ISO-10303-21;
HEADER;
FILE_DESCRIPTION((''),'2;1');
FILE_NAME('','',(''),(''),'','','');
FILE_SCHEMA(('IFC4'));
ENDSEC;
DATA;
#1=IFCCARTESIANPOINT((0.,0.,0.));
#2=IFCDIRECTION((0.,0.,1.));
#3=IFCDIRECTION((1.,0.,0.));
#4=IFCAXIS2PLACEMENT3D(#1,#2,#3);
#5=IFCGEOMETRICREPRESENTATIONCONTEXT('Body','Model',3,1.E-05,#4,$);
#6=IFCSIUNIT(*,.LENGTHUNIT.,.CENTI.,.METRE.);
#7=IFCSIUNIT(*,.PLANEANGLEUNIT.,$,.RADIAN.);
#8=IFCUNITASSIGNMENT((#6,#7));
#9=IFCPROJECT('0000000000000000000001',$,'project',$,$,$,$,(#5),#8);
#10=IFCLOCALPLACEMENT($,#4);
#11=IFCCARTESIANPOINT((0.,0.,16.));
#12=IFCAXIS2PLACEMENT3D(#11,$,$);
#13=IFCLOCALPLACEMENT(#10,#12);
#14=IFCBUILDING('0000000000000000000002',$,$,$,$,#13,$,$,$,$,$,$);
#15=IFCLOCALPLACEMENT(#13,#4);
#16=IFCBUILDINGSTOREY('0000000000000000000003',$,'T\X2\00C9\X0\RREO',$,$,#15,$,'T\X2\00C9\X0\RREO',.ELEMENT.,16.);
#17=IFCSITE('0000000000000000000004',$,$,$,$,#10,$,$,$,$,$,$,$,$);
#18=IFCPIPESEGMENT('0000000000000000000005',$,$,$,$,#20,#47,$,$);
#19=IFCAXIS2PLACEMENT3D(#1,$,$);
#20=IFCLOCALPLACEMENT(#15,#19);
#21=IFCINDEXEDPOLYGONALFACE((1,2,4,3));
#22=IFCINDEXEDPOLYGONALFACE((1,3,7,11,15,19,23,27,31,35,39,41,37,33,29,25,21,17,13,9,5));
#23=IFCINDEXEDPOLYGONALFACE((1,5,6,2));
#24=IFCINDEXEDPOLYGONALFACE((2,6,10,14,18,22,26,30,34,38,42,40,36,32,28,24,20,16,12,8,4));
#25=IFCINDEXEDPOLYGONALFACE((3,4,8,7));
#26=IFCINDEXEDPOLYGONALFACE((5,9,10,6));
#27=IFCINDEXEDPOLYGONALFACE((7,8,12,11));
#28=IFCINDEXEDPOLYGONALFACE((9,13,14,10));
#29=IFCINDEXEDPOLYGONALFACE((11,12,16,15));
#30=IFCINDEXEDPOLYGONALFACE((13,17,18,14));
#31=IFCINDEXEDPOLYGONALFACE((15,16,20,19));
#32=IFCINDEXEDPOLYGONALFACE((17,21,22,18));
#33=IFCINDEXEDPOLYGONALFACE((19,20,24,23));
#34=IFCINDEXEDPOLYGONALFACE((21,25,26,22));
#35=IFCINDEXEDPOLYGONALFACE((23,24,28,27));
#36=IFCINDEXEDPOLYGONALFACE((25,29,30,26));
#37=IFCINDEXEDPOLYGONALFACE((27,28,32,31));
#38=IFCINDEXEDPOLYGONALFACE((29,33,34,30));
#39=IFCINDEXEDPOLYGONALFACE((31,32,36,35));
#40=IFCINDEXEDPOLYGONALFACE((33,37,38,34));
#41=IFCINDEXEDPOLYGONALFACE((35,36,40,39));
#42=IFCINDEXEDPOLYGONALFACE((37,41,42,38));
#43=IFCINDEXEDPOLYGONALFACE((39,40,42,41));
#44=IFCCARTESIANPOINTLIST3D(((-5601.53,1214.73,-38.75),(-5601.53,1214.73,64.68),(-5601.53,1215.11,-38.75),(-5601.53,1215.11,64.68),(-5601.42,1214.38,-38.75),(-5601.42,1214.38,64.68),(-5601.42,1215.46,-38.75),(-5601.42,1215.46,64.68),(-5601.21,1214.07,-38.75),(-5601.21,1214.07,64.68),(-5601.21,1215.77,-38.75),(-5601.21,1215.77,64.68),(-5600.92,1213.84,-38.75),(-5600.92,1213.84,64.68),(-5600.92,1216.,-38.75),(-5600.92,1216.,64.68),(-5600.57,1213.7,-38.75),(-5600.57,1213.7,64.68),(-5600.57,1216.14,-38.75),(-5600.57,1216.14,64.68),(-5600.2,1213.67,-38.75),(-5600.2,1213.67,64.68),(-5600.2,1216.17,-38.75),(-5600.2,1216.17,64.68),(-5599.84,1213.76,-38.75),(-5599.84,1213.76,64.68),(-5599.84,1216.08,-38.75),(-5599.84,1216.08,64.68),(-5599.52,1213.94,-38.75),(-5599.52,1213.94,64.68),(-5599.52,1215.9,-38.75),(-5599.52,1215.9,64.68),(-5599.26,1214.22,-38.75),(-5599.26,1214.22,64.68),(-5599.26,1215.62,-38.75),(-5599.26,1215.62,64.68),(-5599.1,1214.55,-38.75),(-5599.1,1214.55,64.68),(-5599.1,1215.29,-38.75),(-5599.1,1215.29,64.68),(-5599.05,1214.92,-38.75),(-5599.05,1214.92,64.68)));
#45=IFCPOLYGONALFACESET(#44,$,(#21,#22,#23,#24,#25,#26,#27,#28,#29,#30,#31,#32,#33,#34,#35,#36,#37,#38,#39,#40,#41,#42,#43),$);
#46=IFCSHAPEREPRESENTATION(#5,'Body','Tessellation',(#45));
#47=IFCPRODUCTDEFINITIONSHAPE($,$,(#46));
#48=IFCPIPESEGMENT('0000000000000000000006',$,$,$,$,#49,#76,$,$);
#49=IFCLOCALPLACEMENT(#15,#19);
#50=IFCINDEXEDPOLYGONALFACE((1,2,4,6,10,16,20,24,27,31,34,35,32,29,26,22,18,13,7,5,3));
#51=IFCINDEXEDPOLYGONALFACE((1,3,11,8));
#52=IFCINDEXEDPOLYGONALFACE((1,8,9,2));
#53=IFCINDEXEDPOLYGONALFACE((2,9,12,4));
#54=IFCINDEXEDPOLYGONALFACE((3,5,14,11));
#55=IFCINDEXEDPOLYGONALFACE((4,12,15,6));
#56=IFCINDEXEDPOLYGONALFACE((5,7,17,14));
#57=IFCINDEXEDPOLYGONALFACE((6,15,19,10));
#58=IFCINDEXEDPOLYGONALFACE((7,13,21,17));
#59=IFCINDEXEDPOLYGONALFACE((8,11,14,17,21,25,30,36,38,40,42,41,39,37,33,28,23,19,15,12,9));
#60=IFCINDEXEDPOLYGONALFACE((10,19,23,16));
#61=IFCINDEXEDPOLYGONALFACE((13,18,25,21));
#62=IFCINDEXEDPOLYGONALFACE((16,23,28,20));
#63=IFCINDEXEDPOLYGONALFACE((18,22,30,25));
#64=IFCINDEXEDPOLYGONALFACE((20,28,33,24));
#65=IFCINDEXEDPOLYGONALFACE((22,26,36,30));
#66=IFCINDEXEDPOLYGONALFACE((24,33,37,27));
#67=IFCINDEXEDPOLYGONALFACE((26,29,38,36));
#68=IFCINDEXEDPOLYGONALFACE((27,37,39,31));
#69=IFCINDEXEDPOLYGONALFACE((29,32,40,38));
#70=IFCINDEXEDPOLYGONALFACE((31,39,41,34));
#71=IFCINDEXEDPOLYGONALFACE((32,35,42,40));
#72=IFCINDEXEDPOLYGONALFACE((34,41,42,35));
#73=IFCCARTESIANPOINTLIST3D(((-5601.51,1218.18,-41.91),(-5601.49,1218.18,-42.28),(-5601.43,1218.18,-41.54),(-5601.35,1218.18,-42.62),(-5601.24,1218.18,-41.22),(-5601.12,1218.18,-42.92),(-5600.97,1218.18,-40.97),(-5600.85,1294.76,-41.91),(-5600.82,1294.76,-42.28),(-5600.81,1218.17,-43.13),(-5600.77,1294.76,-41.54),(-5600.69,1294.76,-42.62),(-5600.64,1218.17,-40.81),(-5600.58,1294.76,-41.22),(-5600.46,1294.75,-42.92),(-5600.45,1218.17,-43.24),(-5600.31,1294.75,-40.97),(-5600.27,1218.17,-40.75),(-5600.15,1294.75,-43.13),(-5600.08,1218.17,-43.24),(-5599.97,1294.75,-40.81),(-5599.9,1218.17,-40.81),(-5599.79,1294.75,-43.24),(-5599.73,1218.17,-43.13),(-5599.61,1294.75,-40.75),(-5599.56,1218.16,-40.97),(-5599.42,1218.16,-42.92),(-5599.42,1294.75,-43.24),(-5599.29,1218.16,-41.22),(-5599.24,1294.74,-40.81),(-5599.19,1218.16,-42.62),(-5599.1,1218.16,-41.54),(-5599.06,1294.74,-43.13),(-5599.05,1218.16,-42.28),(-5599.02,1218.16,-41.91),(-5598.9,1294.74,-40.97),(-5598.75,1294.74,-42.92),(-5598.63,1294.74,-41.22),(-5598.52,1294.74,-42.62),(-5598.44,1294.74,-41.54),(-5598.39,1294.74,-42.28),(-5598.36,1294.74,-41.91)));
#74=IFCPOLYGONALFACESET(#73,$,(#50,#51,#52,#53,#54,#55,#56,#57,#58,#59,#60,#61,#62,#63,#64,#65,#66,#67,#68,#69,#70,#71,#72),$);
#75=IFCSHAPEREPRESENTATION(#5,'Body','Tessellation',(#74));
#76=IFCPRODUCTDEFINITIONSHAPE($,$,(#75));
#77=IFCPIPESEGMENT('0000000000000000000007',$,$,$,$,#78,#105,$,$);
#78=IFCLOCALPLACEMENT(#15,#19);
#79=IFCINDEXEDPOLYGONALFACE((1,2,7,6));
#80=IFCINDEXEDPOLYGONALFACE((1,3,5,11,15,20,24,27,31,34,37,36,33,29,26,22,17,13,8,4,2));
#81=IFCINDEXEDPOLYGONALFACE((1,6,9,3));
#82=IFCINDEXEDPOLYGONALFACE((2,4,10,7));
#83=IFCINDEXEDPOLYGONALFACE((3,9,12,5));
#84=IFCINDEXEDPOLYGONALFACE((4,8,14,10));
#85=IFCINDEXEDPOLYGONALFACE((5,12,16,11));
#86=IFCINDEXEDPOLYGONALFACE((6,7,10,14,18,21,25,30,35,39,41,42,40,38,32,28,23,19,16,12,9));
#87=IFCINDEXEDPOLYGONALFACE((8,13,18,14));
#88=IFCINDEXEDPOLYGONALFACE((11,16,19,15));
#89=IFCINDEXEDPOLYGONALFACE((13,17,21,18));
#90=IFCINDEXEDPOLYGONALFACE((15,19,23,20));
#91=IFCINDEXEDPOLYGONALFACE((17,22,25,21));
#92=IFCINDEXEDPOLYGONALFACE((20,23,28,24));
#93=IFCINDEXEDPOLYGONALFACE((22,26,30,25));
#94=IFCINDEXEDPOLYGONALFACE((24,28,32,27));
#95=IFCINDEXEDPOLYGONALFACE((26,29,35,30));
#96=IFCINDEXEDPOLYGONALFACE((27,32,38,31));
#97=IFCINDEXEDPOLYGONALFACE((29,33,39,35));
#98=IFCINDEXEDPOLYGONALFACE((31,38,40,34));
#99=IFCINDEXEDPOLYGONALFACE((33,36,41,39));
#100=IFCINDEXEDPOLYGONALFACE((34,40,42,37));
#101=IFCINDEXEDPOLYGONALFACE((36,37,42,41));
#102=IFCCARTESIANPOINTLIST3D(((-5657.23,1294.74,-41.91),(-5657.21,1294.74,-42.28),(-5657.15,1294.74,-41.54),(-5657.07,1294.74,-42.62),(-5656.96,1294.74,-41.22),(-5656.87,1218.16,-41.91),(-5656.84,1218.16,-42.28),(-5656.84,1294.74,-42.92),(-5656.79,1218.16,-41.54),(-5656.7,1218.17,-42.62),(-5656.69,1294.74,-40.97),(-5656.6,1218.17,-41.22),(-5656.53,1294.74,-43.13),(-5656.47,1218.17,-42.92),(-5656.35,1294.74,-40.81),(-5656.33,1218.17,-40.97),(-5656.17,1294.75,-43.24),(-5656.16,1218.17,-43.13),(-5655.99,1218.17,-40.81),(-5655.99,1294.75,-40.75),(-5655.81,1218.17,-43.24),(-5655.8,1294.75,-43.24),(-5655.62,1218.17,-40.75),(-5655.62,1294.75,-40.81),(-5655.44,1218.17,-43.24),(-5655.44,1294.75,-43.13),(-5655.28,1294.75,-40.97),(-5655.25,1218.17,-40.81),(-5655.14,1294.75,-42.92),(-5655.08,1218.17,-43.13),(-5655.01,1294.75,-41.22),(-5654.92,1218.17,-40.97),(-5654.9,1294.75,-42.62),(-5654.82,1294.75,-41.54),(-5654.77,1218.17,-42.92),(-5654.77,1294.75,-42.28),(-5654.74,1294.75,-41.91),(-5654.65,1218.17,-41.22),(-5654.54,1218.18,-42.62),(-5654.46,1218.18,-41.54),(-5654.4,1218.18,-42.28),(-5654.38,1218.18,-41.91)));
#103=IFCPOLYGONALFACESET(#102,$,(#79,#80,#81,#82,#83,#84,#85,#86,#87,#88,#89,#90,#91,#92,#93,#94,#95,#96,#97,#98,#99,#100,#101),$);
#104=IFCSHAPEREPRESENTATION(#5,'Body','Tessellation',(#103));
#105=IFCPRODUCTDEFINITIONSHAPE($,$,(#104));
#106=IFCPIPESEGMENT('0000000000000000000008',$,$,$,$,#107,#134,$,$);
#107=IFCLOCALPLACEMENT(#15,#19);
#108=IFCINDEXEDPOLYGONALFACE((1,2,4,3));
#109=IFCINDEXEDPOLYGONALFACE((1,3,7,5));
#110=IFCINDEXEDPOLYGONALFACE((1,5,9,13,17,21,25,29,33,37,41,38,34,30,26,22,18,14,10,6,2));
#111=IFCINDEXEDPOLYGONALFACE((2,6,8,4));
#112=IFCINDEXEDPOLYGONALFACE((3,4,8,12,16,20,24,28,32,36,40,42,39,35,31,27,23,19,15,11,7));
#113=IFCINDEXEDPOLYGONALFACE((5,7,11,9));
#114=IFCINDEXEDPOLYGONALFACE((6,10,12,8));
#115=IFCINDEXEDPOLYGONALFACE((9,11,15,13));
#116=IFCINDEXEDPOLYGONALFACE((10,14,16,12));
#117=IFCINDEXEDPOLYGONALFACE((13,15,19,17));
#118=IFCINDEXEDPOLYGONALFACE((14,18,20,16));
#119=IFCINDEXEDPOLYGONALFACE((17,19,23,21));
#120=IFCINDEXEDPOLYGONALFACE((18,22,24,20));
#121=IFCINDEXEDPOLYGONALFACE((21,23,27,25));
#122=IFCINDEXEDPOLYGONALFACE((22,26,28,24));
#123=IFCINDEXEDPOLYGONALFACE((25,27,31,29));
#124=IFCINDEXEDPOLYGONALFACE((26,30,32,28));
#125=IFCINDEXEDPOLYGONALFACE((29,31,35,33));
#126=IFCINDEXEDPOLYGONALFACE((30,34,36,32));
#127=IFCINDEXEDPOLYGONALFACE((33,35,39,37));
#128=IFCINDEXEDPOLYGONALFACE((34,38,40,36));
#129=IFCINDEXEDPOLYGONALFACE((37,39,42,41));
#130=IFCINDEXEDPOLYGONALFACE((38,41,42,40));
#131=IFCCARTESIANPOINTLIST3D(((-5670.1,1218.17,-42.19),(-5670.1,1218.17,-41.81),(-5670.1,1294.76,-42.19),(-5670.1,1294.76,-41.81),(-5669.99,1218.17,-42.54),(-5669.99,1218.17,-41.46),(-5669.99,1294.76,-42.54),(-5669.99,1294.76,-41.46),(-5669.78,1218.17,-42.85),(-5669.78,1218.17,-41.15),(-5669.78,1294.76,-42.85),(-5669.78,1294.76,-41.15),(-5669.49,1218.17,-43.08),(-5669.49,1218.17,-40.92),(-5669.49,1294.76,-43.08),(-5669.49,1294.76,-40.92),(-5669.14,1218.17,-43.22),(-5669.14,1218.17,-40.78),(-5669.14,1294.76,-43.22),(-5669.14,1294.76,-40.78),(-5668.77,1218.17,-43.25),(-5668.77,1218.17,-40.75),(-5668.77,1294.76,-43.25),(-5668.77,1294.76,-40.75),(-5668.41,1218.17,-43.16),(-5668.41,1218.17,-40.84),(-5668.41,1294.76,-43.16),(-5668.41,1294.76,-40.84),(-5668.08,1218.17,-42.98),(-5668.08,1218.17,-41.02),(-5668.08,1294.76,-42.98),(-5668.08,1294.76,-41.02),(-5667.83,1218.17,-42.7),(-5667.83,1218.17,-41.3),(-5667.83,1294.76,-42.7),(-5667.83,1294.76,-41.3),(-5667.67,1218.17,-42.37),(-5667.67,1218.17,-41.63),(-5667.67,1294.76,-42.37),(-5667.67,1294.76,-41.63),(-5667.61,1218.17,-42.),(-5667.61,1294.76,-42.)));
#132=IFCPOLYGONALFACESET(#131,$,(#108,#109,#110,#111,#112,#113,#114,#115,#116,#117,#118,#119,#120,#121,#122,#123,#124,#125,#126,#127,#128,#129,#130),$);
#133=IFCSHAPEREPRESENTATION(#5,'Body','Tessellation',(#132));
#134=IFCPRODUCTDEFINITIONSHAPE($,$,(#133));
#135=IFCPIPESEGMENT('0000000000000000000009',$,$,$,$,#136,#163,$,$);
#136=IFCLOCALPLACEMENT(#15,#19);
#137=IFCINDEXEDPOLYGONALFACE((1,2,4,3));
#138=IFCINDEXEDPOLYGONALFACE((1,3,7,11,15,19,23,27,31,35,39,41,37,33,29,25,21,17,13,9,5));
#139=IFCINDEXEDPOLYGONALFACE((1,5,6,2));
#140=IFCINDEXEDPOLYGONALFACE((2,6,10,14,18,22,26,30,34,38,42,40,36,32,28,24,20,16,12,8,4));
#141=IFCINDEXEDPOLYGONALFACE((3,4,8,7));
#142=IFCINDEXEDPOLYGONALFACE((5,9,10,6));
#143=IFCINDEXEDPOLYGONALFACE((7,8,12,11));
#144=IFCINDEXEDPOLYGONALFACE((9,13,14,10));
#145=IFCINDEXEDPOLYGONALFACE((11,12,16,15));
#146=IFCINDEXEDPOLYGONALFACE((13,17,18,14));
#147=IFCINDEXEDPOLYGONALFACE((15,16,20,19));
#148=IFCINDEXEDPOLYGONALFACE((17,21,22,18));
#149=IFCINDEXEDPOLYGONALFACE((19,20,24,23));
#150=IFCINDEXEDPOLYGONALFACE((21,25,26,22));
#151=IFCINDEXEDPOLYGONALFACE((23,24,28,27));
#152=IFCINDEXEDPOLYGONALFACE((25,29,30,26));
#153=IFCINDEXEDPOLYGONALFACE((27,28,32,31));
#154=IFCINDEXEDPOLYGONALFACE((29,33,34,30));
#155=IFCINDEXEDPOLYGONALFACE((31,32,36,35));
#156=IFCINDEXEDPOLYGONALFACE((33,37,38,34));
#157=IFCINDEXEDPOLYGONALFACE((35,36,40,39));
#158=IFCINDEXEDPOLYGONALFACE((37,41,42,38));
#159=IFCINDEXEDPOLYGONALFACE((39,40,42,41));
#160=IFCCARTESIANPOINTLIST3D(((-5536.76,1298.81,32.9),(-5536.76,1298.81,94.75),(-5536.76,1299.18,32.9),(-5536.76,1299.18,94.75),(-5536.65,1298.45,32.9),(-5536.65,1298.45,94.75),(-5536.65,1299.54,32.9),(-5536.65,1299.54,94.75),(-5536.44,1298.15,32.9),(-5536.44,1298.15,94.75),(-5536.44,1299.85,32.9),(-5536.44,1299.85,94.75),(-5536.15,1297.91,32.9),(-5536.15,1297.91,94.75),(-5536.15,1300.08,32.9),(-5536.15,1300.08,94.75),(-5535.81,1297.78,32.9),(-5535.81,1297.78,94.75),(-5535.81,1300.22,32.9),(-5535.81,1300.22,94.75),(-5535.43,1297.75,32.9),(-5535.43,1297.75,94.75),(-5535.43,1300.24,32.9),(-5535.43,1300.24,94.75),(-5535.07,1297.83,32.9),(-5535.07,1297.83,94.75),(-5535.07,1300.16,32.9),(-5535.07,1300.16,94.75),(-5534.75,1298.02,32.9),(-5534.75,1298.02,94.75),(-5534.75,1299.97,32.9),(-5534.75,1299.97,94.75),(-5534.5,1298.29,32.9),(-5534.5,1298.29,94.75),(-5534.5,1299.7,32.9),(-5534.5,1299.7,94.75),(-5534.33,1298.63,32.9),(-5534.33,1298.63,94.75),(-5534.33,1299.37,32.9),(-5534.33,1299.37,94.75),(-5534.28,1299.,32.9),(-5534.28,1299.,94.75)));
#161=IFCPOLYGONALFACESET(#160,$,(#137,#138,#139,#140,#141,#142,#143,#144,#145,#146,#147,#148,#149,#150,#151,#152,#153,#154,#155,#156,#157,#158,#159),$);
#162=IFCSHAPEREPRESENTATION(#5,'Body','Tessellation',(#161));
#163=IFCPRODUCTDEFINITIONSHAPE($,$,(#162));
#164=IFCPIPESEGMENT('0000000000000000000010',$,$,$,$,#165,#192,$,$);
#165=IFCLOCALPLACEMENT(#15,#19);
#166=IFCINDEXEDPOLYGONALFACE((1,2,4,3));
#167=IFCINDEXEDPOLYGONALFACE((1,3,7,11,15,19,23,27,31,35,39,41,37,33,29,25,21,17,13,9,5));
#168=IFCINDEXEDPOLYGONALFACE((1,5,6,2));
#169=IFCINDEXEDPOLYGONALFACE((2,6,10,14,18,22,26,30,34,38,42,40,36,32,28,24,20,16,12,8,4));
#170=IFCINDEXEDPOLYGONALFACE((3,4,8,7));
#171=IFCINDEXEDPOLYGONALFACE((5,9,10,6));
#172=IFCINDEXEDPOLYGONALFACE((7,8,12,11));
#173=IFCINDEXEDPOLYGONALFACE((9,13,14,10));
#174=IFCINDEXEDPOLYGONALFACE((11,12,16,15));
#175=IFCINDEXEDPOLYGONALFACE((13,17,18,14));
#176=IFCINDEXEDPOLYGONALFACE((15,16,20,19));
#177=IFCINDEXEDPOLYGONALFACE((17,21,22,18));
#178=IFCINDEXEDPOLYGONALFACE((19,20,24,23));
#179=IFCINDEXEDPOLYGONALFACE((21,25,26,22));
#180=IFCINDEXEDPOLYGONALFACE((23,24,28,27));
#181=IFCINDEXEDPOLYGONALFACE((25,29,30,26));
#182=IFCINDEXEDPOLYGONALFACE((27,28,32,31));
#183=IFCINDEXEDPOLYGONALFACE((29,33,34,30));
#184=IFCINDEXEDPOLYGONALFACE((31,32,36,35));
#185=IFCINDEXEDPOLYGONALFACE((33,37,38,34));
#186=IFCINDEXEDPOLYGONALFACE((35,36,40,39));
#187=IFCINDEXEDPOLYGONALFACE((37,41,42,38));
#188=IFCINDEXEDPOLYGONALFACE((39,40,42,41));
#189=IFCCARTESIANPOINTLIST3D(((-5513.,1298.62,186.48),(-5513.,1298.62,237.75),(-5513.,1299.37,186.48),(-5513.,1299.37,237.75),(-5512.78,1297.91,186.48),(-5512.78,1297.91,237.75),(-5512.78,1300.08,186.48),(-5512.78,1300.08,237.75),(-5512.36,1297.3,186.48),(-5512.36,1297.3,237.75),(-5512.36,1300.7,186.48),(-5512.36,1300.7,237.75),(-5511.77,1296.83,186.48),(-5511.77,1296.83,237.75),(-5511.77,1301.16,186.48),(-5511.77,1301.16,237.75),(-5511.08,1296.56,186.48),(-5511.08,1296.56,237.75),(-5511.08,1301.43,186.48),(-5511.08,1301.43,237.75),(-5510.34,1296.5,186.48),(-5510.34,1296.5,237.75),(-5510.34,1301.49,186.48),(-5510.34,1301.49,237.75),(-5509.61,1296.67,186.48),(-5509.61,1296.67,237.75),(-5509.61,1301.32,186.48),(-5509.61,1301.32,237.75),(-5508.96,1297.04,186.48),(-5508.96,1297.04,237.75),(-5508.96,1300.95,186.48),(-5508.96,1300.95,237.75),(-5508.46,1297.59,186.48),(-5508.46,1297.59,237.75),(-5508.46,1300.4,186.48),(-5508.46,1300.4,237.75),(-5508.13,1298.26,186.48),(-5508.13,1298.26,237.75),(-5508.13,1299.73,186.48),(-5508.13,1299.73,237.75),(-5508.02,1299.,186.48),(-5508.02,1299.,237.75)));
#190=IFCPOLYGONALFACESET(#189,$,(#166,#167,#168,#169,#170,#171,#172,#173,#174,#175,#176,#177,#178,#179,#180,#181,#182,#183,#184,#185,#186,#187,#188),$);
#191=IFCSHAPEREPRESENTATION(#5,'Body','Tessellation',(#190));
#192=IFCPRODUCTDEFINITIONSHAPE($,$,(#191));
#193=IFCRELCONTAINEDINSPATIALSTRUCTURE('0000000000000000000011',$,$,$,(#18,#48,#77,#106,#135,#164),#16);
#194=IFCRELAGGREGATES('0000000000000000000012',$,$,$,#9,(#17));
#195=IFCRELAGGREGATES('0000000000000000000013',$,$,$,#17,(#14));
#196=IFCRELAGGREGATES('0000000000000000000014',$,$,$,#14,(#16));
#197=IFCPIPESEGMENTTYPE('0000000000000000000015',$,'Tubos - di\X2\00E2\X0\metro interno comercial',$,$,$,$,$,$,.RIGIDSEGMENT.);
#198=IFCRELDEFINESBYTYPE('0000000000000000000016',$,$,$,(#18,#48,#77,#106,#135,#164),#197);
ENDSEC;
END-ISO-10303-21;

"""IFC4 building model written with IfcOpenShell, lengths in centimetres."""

from ifc_helpers import new_model, si_unit, frame, origin_with_axes, origin_2d_with_axis, place, context, project, spatial, circle, extrude, type_object, element, save


model = new_model("IFC4")

# Units and contexts
model_context = context("Model", 3, precision=1e-05, world=origin_with_axes(), identifier="Body")
ifc_project = project(units=[si_unit("LENGTHUNIT", "METRE", prefix="CENTI"), si_unit("PLANEANGLEUNIT", "RADIAN")], contexts=[model_context])

# Site, building, storey
site_placement = place(None, origin_with_axes())
site = spatial("IfcSite", under=ifc_project, at=site_placement)
building_placement = place(site_placement, frame((0.0, 0.0, 16.0)))
building = spatial("IfcBuilding", under=site, at=building_placement)
storey_placement = place(building_placement, origin_with_axes())
storey = spatial("IfcBuildingStorey", under=building, at=storey_placement, Name="TÉRREO", LongName="TÉRREO", CompositionType="ELEMENT", Elevation=16.0)

# Pipe segments
pipe_segment_type = type_object("IfcPipeSegmentType", Name="Tubos - diâmetro interno comercial", PredefinedType="RIGIDSEGMENT")
pipe_segment_1_placement = place(storey_placement, frame((-5600.3, 1214.92, 64.68), z_axis=(0.0, 0.0, 1.0), x_axis=(1.0, 0.0, 0.0)))
element("IfcPipeSegment", 1, at=pipe_segment_1_placement, inside=storey, type_object=pipe_segment_type, context=model_context, shape_type="SolidModel", body=[
    extrude(circle(Radius=1.25, at=origin_2d_with_axis()), frame((0.0, 0.0, 0.0), z_axis=(0.0, 0.0, -1.0), x_axis=(1.0, 0.0, 0.0)), (0.0, 0.0, 1.0), 103.43),
])
pipe_segment_2_placement = place(storey_placement, frame((-5599.94, 1256.46, -40.75), z_axis=(0.0, 0.0, 1.0), x_axis=(1.0, 0.0, 0.0)))
element("IfcPipeSegment", 2, at=pipe_segment_2_placement, inside=storey, type_object=pipe_segment_type, context=model_context, shape_type="SolidModel", body=[
    extrude(circle(Radius=1.25, at=origin_2d_with_axis()), frame((-0.33, -38.29, -1.25), z_axis=(0.008653, 1.0, 0.0), x_axis=(0.0, 0.0, 1.0)), (0.0, 0.0, 1.0), 76.58),
])
pipe_segment_3_placement = place(storey_placement, frame((-5655.8, 1256.46, -40.75), z_axis=(0.0, 0.0, 1.0), x_axis=(1.0, 0.0, 0.0)))
element("IfcPipeSegment", 3, at=pipe_segment_3_placement, inside=storey, type_object=pipe_segment_type, context=model_context, shape_type="SolidModel", body=[
    extrude(circle(Radius=1.25, at=origin_2d_with_axis()), frame((0.18, -38.29, -1.25), z_axis=(-0.004753, 1.0, 0.0), x_axis=(0.0, 0.0, 1.0)), (0.0, 0.0, 1.0), 76.58),
])
pipe_segment_4_placement = place(storey_placement, frame((-5668.86, 1256.46, -40.75), z_axis=(0.0, 0.0, 1.0), x_axis=(1.0, 0.0, 0.0)))
element("IfcPipeSegment", 4, at=pipe_segment_4_placement, inside=storey, type_object=pipe_segment_type, context=model_context, shape_type="SolidModel", body=[
    extrude(circle(Radius=1.25, at=origin_2d_with_axis()), frame((0.0, 38.29, -1.25), z_axis=(0.0, -1.0, 0.0), x_axis=(1.0, 0.0, 0.0)), (0.0, 0.0, 1.0), 76.59),
])
pipe_segment_5_placement = place(storey_placement, frame((-5535.53, 1299.0, 94.75), z_axis=(0.0, 0.0, 1.0), x_axis=(1.0, 0.0, 0.0)))
element("IfcPipeSegment", 5, at=pipe_segment_5_placement, inside=storey, type_object=pipe_segment_type, context=model_context, shape_type="SolidModel", body=[
    extrude(circle(Radius=1.25, at=origin_2d_with_axis()), frame((0.0, 0.0, 0.0), z_axis=(0.0, 0.0, -1.0), x_axis=(1.0, 0.0, 0.0)), (0.0, 0.0, 1.0), 61.85),
])
pipe_segment_6_placement = place(storey_placement, frame((-5510.52, 1299.0, 237.75), z_axis=(0.0, 0.0, 1.0), x_axis=(1.0, 0.0, 0.0)))
element("IfcPipeSegment", 6, at=pipe_segment_6_placement, inside=storey, type_object=pipe_segment_type, context=model_context, shape_type="SolidModel", body=[
    extrude(circle(Radius=2.5, at=origin_2d_with_axis()), frame((0.0, 0.0, 0.0), z_axis=(0.0, 0.0, -1.0), x_axis=(1.0, 0.0, 0.0)), (0.0, 0.0, 1.0), 51.27),
])

save(model, "model.ifc")
